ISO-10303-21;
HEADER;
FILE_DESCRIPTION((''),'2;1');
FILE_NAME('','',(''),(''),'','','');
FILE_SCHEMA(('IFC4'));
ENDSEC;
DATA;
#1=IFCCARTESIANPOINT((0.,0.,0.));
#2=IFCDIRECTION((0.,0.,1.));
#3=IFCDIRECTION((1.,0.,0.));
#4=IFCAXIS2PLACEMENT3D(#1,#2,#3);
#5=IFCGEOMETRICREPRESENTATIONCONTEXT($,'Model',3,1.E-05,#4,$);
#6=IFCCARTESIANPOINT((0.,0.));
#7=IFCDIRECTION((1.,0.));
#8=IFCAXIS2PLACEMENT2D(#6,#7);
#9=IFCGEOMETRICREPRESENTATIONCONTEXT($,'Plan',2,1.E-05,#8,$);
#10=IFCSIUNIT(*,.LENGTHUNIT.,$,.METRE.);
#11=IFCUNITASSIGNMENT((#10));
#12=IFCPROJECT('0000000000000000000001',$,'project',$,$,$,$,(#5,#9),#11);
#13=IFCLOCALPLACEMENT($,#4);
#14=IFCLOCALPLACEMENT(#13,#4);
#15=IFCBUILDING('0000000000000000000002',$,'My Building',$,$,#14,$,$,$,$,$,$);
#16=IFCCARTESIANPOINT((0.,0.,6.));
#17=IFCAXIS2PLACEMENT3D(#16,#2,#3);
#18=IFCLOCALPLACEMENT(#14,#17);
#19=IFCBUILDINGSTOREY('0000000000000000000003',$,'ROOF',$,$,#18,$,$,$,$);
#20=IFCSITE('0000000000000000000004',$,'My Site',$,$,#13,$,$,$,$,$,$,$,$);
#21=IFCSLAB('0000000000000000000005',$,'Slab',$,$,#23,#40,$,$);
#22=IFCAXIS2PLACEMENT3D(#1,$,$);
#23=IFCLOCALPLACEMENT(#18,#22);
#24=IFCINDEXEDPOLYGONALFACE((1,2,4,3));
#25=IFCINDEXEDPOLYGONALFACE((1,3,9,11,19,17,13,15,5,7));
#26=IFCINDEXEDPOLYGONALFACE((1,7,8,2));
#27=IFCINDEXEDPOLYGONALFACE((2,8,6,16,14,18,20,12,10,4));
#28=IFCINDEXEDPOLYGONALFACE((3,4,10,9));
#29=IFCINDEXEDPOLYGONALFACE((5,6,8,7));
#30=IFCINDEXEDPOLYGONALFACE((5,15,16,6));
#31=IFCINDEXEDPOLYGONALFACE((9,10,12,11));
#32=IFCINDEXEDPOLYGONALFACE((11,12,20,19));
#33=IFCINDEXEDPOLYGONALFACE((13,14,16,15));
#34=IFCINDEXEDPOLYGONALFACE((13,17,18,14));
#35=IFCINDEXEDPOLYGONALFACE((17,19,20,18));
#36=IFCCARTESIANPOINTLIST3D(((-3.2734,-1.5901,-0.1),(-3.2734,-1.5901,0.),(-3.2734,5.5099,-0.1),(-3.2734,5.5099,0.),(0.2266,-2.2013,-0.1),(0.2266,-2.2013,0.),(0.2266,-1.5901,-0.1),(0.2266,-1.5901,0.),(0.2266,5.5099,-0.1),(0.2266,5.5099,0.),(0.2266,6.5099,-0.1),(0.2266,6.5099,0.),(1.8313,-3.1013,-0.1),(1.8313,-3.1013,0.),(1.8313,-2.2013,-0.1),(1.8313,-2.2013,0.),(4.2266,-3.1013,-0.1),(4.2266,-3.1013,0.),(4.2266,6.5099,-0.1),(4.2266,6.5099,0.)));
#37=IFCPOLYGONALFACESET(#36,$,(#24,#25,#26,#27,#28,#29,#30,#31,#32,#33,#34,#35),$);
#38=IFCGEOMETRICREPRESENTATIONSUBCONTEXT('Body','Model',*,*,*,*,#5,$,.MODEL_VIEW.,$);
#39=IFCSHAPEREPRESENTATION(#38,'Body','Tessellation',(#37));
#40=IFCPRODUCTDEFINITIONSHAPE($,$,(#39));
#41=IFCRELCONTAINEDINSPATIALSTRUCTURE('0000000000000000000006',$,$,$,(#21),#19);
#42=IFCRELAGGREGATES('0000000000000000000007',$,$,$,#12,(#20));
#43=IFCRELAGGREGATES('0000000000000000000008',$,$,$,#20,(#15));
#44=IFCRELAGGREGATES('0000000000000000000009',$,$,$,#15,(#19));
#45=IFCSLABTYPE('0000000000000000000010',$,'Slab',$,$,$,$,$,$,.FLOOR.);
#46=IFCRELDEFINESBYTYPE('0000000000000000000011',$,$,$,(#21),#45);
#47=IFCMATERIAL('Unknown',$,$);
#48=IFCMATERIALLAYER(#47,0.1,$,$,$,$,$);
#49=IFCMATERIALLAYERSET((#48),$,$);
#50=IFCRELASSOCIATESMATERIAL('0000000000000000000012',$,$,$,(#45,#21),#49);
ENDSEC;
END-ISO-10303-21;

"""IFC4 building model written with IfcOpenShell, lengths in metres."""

from ifc_helpers import new_model, si_unit, frame, origin_with_axes, origin_2d_with_axis, place, context, subcontext, project, spatial, indexed_curve, outline, extrude, material, layer, layer_set, layer_usage, type_object, element, save


model = new_model("IFC4")

# Units and contexts
model_context = context("Model", 3, precision=1e-05, world=origin_with_axes())
plan_context = context("Plan", 2, precision=1e-05, world=origin_2d_with_axis())
body_context = subcontext(model_context, "Body", "Model", "MODEL_VIEW")
ifc_project = project(units=[si_unit("LENGTHUNIT", "METRE")], contexts=[model_context, plan_context])

# Site, building, storey
site_placement = place(None, origin_with_axes())
site = spatial("IfcSite", under=ifc_project, at=site_placement, Name="My Site")
building_placement = place(site_placement, origin_with_axes())
building = spatial("IfcBuilding", under=site, at=building_placement, Name="My Building")
storey_placement = place(building_placement, frame((0.0, 0.0, 6.0), z_axis=(0.0, 0.0, 1.0), x_axis=(1.0, 0.0, 0.0)))
storey = spatial("IfcBuildingStorey", under=building, at=storey_placement, Name="ROOF")

# Slab
ifc_material = material(Name="Unknown")
ifc_layer = layer(ifc_material, 0.1)
ifc_layer_set = layer_set([ifc_layer])
ifc_layer_usage = layer_usage(ifc_layer_set, "AXIS3", "POSITIVE", -0.1)
slab_type = type_object("IfcSlabType", Name="Slab", PredefinedType="FLOOR", material=ifc_layer_set)
slab_placement = place(storey_placement, frame((4.2266, -3.1013, 0.0), z_axis=(0.0, 0.0, 1.0), x_axis=(1.0, 0.0, 0.0)))
element("IfcSlab", 1, at=slab_placement, inside=storey, type_object=slab_type, material=ifc_layer_usage, Name="Slab", context=body_context, shape_type="SweptSolid", body=[
    extrude(outline(indexed_curve([(0.0, 0.0), (0.0, 9.6112), (-4.0, 9.6112), (-4.0, 8.6112), (-7.5, 8.6112), (-7.5, 1.5112), (-4.0, 1.5112), (-4.0, 0.9), (-2.3953, 0.9), (-2.3953, 0.0), (0.0, 0.0)])), frame((0.0, 0.0, -0.1), z_axis=(0.0, 0.0, 1.0), x_axis=(1.0, 0.0, 0.0)), (0.0, 0.0, 1.0), 0.1),
])

save(model, "model.ifc")
